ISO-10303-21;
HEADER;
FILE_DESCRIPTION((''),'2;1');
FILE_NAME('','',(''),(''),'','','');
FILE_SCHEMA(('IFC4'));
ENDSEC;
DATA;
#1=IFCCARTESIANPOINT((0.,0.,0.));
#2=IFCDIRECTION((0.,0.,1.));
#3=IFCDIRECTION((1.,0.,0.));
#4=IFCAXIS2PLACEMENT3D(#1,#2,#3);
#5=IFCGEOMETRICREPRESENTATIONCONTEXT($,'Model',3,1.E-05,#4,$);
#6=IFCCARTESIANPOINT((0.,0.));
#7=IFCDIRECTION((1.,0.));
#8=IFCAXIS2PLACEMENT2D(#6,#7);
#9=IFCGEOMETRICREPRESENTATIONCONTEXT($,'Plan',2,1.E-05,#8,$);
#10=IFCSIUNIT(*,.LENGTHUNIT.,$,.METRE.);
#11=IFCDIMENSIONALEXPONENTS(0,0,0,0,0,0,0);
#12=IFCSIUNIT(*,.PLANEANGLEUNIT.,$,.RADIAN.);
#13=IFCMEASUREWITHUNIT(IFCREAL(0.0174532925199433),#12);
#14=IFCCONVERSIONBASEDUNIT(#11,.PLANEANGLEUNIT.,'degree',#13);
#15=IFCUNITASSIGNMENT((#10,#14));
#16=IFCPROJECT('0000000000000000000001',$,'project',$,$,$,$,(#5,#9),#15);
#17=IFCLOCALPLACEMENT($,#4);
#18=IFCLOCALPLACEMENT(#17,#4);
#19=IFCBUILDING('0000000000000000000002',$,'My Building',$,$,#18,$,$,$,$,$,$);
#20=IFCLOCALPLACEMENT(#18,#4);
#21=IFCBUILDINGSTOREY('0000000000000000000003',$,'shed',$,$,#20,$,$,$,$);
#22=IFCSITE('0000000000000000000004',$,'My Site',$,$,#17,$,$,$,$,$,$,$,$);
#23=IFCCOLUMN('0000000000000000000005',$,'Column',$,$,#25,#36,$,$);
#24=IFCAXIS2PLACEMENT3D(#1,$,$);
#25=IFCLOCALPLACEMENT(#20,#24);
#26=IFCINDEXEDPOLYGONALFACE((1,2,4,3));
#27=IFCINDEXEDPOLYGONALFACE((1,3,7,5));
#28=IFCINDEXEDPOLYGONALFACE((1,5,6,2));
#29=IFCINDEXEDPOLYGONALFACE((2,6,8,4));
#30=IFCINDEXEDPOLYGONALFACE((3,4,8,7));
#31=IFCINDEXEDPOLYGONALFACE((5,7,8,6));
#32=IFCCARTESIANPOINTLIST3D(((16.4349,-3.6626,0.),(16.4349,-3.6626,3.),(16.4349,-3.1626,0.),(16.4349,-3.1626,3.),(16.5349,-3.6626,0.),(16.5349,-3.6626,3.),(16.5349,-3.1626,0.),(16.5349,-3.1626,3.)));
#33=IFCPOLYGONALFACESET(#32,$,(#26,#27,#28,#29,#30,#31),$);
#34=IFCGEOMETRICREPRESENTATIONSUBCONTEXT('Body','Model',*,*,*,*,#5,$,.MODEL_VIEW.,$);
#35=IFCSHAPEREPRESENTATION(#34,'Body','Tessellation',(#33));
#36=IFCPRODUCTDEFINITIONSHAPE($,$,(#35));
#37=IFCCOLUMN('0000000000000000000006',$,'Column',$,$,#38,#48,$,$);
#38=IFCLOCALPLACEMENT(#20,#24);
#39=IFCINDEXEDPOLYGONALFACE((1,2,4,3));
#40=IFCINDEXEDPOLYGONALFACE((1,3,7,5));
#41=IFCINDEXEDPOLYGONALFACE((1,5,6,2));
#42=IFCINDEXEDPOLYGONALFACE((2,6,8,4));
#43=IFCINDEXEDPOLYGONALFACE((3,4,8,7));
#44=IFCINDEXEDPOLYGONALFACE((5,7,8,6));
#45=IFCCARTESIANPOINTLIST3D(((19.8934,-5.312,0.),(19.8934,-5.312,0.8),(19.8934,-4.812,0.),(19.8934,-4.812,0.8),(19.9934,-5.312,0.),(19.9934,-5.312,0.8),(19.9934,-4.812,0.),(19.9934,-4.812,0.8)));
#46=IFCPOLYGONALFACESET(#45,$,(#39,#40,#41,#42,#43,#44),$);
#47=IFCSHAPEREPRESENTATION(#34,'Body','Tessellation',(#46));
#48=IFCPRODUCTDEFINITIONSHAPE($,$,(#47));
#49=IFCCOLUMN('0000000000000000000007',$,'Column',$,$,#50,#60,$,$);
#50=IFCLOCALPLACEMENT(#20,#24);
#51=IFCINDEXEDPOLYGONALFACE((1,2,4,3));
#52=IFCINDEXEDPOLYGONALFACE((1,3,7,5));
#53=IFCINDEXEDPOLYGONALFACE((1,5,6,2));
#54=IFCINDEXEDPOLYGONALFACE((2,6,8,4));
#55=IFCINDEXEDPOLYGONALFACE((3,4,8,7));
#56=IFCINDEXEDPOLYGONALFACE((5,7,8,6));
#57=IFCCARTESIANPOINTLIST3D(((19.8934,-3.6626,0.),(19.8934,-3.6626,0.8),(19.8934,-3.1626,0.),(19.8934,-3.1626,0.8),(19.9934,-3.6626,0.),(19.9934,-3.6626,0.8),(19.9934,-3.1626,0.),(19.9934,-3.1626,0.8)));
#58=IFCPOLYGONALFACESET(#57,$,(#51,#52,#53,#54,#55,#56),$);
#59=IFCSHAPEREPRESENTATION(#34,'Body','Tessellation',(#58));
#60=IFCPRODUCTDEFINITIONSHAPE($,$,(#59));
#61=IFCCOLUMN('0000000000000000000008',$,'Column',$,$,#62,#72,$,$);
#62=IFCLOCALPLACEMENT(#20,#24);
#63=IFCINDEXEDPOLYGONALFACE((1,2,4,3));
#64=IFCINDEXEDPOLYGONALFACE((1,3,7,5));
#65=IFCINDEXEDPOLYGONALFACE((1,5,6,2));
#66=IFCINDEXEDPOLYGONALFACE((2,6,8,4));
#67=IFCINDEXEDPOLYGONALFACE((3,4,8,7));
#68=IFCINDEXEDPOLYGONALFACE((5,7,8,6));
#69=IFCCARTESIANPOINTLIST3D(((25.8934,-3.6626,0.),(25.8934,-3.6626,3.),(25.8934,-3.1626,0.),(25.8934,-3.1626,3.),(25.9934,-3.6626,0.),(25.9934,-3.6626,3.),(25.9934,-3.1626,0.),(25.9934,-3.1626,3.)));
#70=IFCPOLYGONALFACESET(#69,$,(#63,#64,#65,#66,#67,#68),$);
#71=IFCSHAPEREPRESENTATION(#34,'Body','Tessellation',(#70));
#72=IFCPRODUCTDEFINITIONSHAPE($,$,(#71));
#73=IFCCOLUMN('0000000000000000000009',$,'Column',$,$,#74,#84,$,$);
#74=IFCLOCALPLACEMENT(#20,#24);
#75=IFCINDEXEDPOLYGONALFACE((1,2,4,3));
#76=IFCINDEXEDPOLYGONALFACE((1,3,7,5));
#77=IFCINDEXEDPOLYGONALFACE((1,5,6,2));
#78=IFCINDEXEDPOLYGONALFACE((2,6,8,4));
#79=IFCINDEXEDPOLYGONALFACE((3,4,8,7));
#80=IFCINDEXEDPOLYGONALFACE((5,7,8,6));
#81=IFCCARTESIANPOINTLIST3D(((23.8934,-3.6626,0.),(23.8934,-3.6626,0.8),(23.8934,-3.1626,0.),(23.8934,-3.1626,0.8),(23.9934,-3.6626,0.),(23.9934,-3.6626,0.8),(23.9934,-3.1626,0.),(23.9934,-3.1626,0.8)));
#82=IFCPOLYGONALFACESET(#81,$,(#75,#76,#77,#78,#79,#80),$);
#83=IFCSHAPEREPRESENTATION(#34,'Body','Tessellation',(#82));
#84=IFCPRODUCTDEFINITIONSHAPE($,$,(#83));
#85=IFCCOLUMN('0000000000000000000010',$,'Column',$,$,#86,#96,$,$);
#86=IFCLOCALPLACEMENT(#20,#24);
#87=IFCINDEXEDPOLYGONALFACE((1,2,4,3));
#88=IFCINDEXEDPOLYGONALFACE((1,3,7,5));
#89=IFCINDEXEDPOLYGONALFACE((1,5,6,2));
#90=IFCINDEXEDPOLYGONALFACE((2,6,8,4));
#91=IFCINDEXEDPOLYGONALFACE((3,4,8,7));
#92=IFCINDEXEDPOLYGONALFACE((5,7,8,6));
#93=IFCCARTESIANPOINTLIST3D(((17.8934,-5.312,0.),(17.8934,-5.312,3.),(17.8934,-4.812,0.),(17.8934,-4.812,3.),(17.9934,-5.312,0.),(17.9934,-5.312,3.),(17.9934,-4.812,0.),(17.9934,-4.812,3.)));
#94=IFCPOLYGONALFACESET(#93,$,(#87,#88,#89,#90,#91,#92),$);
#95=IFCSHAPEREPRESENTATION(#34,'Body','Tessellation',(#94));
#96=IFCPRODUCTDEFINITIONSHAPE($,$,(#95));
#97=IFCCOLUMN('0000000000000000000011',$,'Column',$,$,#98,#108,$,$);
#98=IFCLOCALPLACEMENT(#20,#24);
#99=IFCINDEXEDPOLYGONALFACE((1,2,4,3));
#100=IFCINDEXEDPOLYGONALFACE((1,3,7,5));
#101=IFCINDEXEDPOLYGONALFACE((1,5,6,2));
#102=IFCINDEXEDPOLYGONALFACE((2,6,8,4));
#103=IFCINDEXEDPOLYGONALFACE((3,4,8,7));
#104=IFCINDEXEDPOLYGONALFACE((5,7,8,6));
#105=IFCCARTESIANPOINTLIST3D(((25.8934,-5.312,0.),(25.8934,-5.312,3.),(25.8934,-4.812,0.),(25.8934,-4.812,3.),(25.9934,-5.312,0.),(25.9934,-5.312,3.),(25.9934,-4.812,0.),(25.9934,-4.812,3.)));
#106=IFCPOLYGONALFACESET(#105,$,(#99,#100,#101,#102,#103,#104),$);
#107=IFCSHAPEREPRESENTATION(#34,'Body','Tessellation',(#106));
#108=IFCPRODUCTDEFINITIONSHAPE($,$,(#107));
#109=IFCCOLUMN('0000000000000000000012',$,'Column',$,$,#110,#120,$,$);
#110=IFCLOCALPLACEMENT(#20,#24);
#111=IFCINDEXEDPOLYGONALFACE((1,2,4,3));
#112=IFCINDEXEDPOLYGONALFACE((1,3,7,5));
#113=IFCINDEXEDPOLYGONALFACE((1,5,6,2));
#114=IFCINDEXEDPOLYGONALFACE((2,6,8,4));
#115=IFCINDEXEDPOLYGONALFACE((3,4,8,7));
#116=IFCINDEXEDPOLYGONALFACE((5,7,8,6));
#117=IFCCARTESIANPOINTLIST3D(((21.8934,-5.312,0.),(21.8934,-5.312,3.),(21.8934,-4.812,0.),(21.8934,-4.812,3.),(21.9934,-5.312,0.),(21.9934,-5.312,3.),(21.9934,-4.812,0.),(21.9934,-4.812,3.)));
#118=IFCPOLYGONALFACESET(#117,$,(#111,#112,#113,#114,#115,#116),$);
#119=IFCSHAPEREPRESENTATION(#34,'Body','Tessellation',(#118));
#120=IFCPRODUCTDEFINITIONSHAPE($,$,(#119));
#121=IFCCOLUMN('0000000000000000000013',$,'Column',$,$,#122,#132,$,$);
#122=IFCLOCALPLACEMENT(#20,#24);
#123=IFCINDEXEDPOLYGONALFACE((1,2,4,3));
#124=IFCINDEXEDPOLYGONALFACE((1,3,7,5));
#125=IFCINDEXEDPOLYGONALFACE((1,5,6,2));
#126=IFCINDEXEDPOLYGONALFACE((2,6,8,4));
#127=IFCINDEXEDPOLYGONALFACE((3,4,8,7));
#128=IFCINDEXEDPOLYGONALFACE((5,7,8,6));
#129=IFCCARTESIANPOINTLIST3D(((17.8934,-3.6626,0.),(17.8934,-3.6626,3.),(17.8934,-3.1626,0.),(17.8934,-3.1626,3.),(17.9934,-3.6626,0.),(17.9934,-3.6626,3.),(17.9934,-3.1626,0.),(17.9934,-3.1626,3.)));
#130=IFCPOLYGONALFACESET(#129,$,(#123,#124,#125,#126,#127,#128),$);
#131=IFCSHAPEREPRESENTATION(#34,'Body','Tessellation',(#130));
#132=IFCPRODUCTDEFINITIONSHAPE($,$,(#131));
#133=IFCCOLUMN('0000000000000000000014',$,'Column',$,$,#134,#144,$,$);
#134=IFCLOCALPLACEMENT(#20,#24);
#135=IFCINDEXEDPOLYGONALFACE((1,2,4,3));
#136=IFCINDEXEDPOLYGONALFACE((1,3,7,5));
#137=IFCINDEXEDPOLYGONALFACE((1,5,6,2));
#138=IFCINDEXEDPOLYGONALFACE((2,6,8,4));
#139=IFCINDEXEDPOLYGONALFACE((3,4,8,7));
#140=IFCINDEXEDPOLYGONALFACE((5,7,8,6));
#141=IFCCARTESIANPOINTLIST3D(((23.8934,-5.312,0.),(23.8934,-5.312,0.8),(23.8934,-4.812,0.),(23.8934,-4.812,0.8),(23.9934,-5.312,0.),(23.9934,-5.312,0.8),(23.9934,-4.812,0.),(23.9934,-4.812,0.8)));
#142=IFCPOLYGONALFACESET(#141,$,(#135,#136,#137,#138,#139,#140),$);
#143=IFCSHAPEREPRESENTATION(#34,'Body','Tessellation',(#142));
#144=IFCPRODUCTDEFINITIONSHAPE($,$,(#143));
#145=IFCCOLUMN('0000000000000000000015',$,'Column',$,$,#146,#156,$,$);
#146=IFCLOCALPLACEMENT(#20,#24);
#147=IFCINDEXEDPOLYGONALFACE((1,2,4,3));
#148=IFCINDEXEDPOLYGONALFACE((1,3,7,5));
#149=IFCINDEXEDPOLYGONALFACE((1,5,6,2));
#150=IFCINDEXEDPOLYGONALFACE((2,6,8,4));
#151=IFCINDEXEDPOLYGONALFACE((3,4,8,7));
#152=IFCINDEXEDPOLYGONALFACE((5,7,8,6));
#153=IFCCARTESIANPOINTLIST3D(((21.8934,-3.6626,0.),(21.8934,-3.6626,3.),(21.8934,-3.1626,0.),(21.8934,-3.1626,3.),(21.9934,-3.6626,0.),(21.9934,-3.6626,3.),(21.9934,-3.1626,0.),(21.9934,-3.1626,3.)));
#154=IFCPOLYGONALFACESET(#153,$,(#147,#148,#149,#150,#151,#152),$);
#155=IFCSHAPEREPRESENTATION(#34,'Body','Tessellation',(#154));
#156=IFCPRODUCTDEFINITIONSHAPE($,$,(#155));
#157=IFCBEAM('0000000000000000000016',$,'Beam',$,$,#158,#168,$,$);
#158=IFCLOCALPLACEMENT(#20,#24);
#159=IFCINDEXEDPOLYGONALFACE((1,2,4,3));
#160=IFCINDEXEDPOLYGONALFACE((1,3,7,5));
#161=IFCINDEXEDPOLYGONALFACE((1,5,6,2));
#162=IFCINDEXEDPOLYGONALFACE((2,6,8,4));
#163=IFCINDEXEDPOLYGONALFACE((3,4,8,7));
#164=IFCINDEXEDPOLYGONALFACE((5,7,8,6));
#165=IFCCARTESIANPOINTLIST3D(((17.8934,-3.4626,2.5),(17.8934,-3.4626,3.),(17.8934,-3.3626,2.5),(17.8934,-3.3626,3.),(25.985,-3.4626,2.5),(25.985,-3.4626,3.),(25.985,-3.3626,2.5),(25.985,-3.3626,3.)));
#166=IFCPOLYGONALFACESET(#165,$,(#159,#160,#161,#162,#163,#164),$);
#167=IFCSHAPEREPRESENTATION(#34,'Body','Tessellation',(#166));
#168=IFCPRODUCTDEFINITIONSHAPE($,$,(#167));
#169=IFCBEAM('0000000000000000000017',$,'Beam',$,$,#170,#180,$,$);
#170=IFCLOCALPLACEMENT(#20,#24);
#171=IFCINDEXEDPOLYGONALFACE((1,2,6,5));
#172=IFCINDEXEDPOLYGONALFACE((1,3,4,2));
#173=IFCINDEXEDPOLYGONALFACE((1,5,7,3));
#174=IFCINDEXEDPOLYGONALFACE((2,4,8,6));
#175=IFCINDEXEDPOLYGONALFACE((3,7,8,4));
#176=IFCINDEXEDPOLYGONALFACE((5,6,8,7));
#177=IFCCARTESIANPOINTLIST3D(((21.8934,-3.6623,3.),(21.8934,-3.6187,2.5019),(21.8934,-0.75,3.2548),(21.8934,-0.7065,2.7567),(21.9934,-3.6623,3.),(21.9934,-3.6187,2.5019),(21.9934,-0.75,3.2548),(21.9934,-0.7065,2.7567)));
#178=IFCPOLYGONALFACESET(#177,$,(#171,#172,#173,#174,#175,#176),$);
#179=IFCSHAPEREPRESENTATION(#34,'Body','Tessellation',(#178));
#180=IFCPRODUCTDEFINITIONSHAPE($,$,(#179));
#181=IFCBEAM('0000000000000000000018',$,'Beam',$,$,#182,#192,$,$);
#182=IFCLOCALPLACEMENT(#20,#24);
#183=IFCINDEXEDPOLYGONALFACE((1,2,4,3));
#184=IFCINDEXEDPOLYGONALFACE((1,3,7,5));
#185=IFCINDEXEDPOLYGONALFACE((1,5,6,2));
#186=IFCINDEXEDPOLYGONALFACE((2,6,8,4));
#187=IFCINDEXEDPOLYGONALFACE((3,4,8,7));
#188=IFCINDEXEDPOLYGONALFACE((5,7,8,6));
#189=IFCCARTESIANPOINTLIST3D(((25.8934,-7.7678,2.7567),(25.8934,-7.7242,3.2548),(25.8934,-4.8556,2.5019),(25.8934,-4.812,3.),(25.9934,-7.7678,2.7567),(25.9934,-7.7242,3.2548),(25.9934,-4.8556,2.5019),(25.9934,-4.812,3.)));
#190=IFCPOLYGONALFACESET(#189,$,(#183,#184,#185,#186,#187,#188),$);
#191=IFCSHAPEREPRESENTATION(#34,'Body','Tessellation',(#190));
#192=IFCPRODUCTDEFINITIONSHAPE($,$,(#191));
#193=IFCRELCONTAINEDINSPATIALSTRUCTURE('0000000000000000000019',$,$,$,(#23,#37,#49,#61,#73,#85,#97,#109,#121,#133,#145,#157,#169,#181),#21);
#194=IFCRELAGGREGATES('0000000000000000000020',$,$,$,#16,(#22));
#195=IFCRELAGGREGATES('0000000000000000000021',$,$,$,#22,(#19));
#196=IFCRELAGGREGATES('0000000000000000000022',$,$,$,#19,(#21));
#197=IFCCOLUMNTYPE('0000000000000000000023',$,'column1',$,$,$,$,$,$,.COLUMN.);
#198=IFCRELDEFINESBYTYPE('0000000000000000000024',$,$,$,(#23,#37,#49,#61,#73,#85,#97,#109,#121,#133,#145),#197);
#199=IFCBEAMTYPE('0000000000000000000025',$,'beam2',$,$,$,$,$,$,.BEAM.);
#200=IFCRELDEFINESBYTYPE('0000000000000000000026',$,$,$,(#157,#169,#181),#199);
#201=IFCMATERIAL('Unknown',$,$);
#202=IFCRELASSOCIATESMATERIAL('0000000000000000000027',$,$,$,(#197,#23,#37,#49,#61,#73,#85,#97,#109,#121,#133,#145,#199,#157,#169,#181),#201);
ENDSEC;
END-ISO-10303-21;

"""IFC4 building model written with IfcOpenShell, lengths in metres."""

from ifc_helpers import new_model, entity, si_unit, converted_unit, frame, origin_with_axes, origin_2d_with_axis, place, context, subcontext, project, spatial, rectangle, extrude, material, material_profile, profile_set, profile_usage, type_object, element, save


model = new_model("IFC4")

# Units and contexts
model_context = context("Model", 3, precision=1e-05, world=origin_with_axes())
plan_context = context("Plan", 2, precision=1e-05, world=origin_2d_with_axis())
body_context = subcontext(model_context, "Body", "Model", "MODEL_VIEW")
ifc_project = project(units=[si_unit("LENGTHUNIT", "METRE"), converted_unit("PLANEANGLEUNIT", "degree", entity("IfcReal", 0.0174532925199433), si_unit("PLANEANGLEUNIT", "RADIAN"), dimensions=[0, 0, 0, 0, 0, 0, 0])], contexts=[model_context, plan_context])

# Site, building, storey
site_placement = place(None, origin_with_axes())
site = spatial("IfcSite", under=ifc_project, at=site_placement, Name="My Site")
building_placement = place(site_placement, origin_with_axes())
building = spatial("IfcBuilding", under=site, at=building_placement, Name="My Building")
storey_placement = place(building_placement, origin_with_axes())
storey = spatial("IfcBuildingStorey", under=building, at=storey_placement, Name="shed")

# Columns
ifc_material = material(Name="Unknown")
ifc_material_profile_1 = material_profile(ifc_material, rectangle(XDim=0.1, YDim=0.5))
ifc_profile_set_1 = profile_set([ifc_material_profile_1])
ifc_profile_usage_1 = profile_usage(ifc_profile_set_1, cardinal=5)
column_type = type_object("IfcColumnType", Name="column1", PredefinedType="COLUMN", material=ifc_profile_set_1)
column_1_placement = place(storey_placement, frame((16.4849, -3.4126, 0.0), z_axis=(0.0, 0.0, 1.0), x_axis=(-1.0, 0.0, 0.0)))
element("IfcColumn", 1, at=column_1_placement, inside=storey, type_object=column_type, material=ifc_profile_usage_1, Name="Column", context=body_context, shape_type="SweptSolid", body=[
    extrude(rectangle(XDim=0.1, YDim=0.5), origin_with_axes(), (0.0, 0.0, 1.0), 3.0),
])
ifc_profile_usage_2 = profile_usage(ifc_profile_set_1, cardinal=5)
column_2_placement = place(storey_placement, frame((19.9434, -5.062, 0.0), z_axis=(0.0, 0.0, 1.0), x_axis=(-1.0, 0.0, 0.0)))
element("IfcColumn", 2, at=column_2_placement, inside=storey, type_object=column_type, material=ifc_profile_usage_2, Name="Column", context=body_context, shape_type="SweptSolid", body=[
    extrude(rectangle(XDim=0.1, YDim=0.5), origin_with_axes(), (0.0, 0.0, 1.0), 0.8),
])
ifc_profile_usage_3 = profile_usage(ifc_profile_set_1, cardinal=5)
column_3_placement = place(storey_placement, frame((19.9434, -3.4126, 0.0), z_axis=(0.0, 0.0, 1.0), x_axis=(-1.0, 0.0, 0.0)))
element("IfcColumn", 3, at=column_3_placement, inside=storey, type_object=column_type, material=ifc_profile_usage_3, Name="Column", context=body_context, shape_type="SweptSolid", body=[
    extrude(rectangle(XDim=0.1, YDim=0.5), origin_with_axes(), (0.0, 0.0, 1.0), 0.8),
])
ifc_profile_usage_4 = profile_usage(ifc_profile_set_1, cardinal=5)
column_4_placement = place(storey_placement, frame((25.9434, -3.4126, 0.0), z_axis=(0.0, 0.0, 1.0), x_axis=(-1.0, 0.0, 0.0)))
element("IfcColumn", 4, at=column_4_placement, inside=storey, type_object=column_type, material=ifc_profile_usage_4, Name="Column", context=body_context, shape_type="SweptSolid", body=[
    extrude(rectangle(XDim=0.1, YDim=0.5), origin_with_axes(), (0.0, 0.0, 1.0), 3.0),
])
ifc_profile_usage_5 = profile_usage(ifc_profile_set_1, cardinal=5)
column_5_placement = place(storey_placement, frame((23.9434, -3.4126, 0.0), z_axis=(0.0, 0.0, 1.0), x_axis=(-1.0, 0.0, 0.0)))
element("IfcColumn", 5, at=column_5_placement, inside=storey, type_object=column_type, material=ifc_profile_usage_5, Name="Column", context=body_context, shape_type="SweptSolid", body=[
    extrude(rectangle(XDim=0.1, YDim=0.5), origin_with_axes(), (0.0, 0.0, 1.0), 0.8),
])
ifc_profile_usage_6 = profile_usage(ifc_profile_set_1, cardinal=5)
column_6_placement = place(storey_placement, frame((17.9434, -5.062, 0.0), z_axis=(0.0, 0.0, 1.0), x_axis=(1.0, 0.0, 0.0)))
element("IfcColumn", 6, at=column_6_placement, inside=storey, type_object=column_type, material=ifc_profile_usage_6, Name="Column", context=body_context, shape_type="SweptSolid", body=[
    extrude(rectangle(XDim=0.1, YDim=0.5), origin_with_axes(), (0.0, 0.0, 1.0), 3.0),
])
ifc_profile_usage_7 = profile_usage(ifc_profile_set_1, cardinal=5)
column_7_placement = place(storey_placement, frame((25.9434, -5.062, 0.0), z_axis=(0.0, 0.0, 1.0), x_axis=(1.0, 0.0, 0.0)))
element("IfcColumn", 7, at=column_7_placement, inside=storey, type_object=column_type, material=ifc_profile_usage_7, Name="Column", context=body_context, shape_type="SweptSolid", body=[
    extrude(rectangle(XDim=0.1, YDim=0.5), origin_with_axes(), (0.0, 0.0, 1.0), 3.0),
])
ifc_profile_usage_8 = profile_usage(ifc_profile_set_1, cardinal=5)
column_8_placement = place(storey_placement, frame((21.9434, -5.062, 0.0), z_axis=(0.0, 0.0, 1.0), x_axis=(1.0, 0.0, 0.0)))
element("IfcColumn", 8, at=column_8_placement, inside=storey, type_object=column_type, material=ifc_profile_usage_8, Name="Column", context=body_context, shape_type="SweptSolid", body=[
    extrude(rectangle(XDim=0.1, YDim=0.5), origin_with_axes(), (0.0, 0.0, 1.0), 3.0),
])
ifc_profile_usage_9 = profile_usage(ifc_profile_set_1, cardinal=5)
column_9_placement = place(storey_placement, frame((17.9434, -3.4126, 0.0), z_axis=(0.0, 0.0, 1.0), x_axis=(-1.0, 0.0, 0.0)))
element("IfcColumn", 9, at=column_9_placement, inside=storey, type_object=column_type, material=ifc_profile_usage_9, Name="Column", context=body_context, shape_type="SweptSolid", body=[
    extrude(rectangle(XDim=0.1, YDim=0.5), origin_with_axes(), (0.0, 0.0, 1.0), 3.0),
])
ifc_profile_usage_10 = profile_usage(ifc_profile_set_1, cardinal=5)
column_10_placement = place(storey_placement, frame((23.9434, -5.062, 0.0), z_axis=(0.0, 0.0, 1.0), x_axis=(-1.0, 0.0, 0.0)))
element("IfcColumn", 10, at=column_10_placement, inside=storey, type_object=column_type, material=ifc_profile_usage_10, Name="Column", context=body_context, shape_type="SweptSolid", body=[
    extrude(rectangle(XDim=0.1, YDim=0.5), origin_with_axes(), (0.0, 0.0, 1.0), 0.8),
])
ifc_profile_usage_11 = profile_usage(ifc_profile_set_1, cardinal=5)
column_11_placement = place(storey_placement, frame((21.9434, -3.4126, 0.0), z_axis=(0.0, 0.0, 1.0), x_axis=(-1.0, 0.0, 0.0)))
element("IfcColumn", 11, at=column_11_placement, inside=storey, type_object=column_type, material=ifc_profile_usage_11, Name="Column", context=body_context, shape_type="SweptSolid", body=[
    extrude(rectangle(XDim=0.1, YDim=0.5), origin_with_axes(), (0.0, 0.0, 1.0), 3.0),
])

# Beams
ifc_material_profile_2 = material_profile(ifc_material, rectangle(XDim=0.1, YDim=0.5))
ifc_profile_set_2 = profile_set([ifc_material_profile_2])
ifc_profile_usage_12 = profile_usage(ifc_profile_set_2, cardinal=8)
beam_type = type_object("IfcBeamType", Name="beam2", PredefinedType="BEAM", material=ifc_profile_set_2)
beam_1_placement = place(storey_placement, frame((17.8934, -3.4126, 3.0), z_axis=(1.0, -0.000001, 0.000001), x_axis=(0.000001, 1.0, 0.0)))
element("IfcBeam", 12, at=beam_1_placement, inside=storey, type_object=beam_type, material=ifc_profile_usage_12, Name="Beam", context=body_context, shape_type="SweptSolid", body=[
    extrude(rectangle(XDim=0.1, YDim=0.5), frame((0.0, -0.25, 0.0), z_axis=(0.0, 0.0, 1.0), x_axis=(1.0, 0.0, 0.0)), (0.0, 0.0, 1.0), 8.0916),
])
ifc_profile_usage_13 = profile_usage(ifc_profile_set_2, cardinal=8)
beam_2_placement = place(storey_placement, frame((21.9434, -3.6623, 3.0), z_axis=(0.0, 0.996195, 0.087156), x_axis=(-1.0, 0.0, 0.0)))
element("IfcBeam", 13, at=beam_2_placement, inside=storey, type_object=beam_type, material=ifc_profile_usage_13, Name="Beam", context=body_context, shape_type="SweptSolid", body=[
    extrude(rectangle(XDim=0.1, YDim=0.5), frame((0.0, -0.25, 0.0), z_axis=(0.0, 0.0, 1.0), x_axis=(1.0, 0.0, 0.0)), (0.0, 0.0, 1.0), 2.9234),
])
ifc_profile_usage_14 = profile_usage(ifc_profile_set_2, cardinal=8)
beam_3_placement = place(storey_placement, frame((25.9434, -4.812, 3.0), z_axis=(0.0, -0.996195, 0.087156), x_axis=(1.0, 0.0, 0.0)))
element("IfcBeam", 14, at=beam_3_placement, inside=storey, type_object=beam_type, material=ifc_profile_usage_14, Name="Beam", context=body_context, shape_type="SweptSolid", body=[
    extrude(rectangle(XDim=0.1, YDim=0.5), frame((0.0, -0.25, 0.0), z_axis=(0.0, 0.0, 1.0), x_axis=(1.0, 0.0, 0.0)), (0.0, 0.0, 1.0), 2.9234),
])

save(model, "model.ifc")
